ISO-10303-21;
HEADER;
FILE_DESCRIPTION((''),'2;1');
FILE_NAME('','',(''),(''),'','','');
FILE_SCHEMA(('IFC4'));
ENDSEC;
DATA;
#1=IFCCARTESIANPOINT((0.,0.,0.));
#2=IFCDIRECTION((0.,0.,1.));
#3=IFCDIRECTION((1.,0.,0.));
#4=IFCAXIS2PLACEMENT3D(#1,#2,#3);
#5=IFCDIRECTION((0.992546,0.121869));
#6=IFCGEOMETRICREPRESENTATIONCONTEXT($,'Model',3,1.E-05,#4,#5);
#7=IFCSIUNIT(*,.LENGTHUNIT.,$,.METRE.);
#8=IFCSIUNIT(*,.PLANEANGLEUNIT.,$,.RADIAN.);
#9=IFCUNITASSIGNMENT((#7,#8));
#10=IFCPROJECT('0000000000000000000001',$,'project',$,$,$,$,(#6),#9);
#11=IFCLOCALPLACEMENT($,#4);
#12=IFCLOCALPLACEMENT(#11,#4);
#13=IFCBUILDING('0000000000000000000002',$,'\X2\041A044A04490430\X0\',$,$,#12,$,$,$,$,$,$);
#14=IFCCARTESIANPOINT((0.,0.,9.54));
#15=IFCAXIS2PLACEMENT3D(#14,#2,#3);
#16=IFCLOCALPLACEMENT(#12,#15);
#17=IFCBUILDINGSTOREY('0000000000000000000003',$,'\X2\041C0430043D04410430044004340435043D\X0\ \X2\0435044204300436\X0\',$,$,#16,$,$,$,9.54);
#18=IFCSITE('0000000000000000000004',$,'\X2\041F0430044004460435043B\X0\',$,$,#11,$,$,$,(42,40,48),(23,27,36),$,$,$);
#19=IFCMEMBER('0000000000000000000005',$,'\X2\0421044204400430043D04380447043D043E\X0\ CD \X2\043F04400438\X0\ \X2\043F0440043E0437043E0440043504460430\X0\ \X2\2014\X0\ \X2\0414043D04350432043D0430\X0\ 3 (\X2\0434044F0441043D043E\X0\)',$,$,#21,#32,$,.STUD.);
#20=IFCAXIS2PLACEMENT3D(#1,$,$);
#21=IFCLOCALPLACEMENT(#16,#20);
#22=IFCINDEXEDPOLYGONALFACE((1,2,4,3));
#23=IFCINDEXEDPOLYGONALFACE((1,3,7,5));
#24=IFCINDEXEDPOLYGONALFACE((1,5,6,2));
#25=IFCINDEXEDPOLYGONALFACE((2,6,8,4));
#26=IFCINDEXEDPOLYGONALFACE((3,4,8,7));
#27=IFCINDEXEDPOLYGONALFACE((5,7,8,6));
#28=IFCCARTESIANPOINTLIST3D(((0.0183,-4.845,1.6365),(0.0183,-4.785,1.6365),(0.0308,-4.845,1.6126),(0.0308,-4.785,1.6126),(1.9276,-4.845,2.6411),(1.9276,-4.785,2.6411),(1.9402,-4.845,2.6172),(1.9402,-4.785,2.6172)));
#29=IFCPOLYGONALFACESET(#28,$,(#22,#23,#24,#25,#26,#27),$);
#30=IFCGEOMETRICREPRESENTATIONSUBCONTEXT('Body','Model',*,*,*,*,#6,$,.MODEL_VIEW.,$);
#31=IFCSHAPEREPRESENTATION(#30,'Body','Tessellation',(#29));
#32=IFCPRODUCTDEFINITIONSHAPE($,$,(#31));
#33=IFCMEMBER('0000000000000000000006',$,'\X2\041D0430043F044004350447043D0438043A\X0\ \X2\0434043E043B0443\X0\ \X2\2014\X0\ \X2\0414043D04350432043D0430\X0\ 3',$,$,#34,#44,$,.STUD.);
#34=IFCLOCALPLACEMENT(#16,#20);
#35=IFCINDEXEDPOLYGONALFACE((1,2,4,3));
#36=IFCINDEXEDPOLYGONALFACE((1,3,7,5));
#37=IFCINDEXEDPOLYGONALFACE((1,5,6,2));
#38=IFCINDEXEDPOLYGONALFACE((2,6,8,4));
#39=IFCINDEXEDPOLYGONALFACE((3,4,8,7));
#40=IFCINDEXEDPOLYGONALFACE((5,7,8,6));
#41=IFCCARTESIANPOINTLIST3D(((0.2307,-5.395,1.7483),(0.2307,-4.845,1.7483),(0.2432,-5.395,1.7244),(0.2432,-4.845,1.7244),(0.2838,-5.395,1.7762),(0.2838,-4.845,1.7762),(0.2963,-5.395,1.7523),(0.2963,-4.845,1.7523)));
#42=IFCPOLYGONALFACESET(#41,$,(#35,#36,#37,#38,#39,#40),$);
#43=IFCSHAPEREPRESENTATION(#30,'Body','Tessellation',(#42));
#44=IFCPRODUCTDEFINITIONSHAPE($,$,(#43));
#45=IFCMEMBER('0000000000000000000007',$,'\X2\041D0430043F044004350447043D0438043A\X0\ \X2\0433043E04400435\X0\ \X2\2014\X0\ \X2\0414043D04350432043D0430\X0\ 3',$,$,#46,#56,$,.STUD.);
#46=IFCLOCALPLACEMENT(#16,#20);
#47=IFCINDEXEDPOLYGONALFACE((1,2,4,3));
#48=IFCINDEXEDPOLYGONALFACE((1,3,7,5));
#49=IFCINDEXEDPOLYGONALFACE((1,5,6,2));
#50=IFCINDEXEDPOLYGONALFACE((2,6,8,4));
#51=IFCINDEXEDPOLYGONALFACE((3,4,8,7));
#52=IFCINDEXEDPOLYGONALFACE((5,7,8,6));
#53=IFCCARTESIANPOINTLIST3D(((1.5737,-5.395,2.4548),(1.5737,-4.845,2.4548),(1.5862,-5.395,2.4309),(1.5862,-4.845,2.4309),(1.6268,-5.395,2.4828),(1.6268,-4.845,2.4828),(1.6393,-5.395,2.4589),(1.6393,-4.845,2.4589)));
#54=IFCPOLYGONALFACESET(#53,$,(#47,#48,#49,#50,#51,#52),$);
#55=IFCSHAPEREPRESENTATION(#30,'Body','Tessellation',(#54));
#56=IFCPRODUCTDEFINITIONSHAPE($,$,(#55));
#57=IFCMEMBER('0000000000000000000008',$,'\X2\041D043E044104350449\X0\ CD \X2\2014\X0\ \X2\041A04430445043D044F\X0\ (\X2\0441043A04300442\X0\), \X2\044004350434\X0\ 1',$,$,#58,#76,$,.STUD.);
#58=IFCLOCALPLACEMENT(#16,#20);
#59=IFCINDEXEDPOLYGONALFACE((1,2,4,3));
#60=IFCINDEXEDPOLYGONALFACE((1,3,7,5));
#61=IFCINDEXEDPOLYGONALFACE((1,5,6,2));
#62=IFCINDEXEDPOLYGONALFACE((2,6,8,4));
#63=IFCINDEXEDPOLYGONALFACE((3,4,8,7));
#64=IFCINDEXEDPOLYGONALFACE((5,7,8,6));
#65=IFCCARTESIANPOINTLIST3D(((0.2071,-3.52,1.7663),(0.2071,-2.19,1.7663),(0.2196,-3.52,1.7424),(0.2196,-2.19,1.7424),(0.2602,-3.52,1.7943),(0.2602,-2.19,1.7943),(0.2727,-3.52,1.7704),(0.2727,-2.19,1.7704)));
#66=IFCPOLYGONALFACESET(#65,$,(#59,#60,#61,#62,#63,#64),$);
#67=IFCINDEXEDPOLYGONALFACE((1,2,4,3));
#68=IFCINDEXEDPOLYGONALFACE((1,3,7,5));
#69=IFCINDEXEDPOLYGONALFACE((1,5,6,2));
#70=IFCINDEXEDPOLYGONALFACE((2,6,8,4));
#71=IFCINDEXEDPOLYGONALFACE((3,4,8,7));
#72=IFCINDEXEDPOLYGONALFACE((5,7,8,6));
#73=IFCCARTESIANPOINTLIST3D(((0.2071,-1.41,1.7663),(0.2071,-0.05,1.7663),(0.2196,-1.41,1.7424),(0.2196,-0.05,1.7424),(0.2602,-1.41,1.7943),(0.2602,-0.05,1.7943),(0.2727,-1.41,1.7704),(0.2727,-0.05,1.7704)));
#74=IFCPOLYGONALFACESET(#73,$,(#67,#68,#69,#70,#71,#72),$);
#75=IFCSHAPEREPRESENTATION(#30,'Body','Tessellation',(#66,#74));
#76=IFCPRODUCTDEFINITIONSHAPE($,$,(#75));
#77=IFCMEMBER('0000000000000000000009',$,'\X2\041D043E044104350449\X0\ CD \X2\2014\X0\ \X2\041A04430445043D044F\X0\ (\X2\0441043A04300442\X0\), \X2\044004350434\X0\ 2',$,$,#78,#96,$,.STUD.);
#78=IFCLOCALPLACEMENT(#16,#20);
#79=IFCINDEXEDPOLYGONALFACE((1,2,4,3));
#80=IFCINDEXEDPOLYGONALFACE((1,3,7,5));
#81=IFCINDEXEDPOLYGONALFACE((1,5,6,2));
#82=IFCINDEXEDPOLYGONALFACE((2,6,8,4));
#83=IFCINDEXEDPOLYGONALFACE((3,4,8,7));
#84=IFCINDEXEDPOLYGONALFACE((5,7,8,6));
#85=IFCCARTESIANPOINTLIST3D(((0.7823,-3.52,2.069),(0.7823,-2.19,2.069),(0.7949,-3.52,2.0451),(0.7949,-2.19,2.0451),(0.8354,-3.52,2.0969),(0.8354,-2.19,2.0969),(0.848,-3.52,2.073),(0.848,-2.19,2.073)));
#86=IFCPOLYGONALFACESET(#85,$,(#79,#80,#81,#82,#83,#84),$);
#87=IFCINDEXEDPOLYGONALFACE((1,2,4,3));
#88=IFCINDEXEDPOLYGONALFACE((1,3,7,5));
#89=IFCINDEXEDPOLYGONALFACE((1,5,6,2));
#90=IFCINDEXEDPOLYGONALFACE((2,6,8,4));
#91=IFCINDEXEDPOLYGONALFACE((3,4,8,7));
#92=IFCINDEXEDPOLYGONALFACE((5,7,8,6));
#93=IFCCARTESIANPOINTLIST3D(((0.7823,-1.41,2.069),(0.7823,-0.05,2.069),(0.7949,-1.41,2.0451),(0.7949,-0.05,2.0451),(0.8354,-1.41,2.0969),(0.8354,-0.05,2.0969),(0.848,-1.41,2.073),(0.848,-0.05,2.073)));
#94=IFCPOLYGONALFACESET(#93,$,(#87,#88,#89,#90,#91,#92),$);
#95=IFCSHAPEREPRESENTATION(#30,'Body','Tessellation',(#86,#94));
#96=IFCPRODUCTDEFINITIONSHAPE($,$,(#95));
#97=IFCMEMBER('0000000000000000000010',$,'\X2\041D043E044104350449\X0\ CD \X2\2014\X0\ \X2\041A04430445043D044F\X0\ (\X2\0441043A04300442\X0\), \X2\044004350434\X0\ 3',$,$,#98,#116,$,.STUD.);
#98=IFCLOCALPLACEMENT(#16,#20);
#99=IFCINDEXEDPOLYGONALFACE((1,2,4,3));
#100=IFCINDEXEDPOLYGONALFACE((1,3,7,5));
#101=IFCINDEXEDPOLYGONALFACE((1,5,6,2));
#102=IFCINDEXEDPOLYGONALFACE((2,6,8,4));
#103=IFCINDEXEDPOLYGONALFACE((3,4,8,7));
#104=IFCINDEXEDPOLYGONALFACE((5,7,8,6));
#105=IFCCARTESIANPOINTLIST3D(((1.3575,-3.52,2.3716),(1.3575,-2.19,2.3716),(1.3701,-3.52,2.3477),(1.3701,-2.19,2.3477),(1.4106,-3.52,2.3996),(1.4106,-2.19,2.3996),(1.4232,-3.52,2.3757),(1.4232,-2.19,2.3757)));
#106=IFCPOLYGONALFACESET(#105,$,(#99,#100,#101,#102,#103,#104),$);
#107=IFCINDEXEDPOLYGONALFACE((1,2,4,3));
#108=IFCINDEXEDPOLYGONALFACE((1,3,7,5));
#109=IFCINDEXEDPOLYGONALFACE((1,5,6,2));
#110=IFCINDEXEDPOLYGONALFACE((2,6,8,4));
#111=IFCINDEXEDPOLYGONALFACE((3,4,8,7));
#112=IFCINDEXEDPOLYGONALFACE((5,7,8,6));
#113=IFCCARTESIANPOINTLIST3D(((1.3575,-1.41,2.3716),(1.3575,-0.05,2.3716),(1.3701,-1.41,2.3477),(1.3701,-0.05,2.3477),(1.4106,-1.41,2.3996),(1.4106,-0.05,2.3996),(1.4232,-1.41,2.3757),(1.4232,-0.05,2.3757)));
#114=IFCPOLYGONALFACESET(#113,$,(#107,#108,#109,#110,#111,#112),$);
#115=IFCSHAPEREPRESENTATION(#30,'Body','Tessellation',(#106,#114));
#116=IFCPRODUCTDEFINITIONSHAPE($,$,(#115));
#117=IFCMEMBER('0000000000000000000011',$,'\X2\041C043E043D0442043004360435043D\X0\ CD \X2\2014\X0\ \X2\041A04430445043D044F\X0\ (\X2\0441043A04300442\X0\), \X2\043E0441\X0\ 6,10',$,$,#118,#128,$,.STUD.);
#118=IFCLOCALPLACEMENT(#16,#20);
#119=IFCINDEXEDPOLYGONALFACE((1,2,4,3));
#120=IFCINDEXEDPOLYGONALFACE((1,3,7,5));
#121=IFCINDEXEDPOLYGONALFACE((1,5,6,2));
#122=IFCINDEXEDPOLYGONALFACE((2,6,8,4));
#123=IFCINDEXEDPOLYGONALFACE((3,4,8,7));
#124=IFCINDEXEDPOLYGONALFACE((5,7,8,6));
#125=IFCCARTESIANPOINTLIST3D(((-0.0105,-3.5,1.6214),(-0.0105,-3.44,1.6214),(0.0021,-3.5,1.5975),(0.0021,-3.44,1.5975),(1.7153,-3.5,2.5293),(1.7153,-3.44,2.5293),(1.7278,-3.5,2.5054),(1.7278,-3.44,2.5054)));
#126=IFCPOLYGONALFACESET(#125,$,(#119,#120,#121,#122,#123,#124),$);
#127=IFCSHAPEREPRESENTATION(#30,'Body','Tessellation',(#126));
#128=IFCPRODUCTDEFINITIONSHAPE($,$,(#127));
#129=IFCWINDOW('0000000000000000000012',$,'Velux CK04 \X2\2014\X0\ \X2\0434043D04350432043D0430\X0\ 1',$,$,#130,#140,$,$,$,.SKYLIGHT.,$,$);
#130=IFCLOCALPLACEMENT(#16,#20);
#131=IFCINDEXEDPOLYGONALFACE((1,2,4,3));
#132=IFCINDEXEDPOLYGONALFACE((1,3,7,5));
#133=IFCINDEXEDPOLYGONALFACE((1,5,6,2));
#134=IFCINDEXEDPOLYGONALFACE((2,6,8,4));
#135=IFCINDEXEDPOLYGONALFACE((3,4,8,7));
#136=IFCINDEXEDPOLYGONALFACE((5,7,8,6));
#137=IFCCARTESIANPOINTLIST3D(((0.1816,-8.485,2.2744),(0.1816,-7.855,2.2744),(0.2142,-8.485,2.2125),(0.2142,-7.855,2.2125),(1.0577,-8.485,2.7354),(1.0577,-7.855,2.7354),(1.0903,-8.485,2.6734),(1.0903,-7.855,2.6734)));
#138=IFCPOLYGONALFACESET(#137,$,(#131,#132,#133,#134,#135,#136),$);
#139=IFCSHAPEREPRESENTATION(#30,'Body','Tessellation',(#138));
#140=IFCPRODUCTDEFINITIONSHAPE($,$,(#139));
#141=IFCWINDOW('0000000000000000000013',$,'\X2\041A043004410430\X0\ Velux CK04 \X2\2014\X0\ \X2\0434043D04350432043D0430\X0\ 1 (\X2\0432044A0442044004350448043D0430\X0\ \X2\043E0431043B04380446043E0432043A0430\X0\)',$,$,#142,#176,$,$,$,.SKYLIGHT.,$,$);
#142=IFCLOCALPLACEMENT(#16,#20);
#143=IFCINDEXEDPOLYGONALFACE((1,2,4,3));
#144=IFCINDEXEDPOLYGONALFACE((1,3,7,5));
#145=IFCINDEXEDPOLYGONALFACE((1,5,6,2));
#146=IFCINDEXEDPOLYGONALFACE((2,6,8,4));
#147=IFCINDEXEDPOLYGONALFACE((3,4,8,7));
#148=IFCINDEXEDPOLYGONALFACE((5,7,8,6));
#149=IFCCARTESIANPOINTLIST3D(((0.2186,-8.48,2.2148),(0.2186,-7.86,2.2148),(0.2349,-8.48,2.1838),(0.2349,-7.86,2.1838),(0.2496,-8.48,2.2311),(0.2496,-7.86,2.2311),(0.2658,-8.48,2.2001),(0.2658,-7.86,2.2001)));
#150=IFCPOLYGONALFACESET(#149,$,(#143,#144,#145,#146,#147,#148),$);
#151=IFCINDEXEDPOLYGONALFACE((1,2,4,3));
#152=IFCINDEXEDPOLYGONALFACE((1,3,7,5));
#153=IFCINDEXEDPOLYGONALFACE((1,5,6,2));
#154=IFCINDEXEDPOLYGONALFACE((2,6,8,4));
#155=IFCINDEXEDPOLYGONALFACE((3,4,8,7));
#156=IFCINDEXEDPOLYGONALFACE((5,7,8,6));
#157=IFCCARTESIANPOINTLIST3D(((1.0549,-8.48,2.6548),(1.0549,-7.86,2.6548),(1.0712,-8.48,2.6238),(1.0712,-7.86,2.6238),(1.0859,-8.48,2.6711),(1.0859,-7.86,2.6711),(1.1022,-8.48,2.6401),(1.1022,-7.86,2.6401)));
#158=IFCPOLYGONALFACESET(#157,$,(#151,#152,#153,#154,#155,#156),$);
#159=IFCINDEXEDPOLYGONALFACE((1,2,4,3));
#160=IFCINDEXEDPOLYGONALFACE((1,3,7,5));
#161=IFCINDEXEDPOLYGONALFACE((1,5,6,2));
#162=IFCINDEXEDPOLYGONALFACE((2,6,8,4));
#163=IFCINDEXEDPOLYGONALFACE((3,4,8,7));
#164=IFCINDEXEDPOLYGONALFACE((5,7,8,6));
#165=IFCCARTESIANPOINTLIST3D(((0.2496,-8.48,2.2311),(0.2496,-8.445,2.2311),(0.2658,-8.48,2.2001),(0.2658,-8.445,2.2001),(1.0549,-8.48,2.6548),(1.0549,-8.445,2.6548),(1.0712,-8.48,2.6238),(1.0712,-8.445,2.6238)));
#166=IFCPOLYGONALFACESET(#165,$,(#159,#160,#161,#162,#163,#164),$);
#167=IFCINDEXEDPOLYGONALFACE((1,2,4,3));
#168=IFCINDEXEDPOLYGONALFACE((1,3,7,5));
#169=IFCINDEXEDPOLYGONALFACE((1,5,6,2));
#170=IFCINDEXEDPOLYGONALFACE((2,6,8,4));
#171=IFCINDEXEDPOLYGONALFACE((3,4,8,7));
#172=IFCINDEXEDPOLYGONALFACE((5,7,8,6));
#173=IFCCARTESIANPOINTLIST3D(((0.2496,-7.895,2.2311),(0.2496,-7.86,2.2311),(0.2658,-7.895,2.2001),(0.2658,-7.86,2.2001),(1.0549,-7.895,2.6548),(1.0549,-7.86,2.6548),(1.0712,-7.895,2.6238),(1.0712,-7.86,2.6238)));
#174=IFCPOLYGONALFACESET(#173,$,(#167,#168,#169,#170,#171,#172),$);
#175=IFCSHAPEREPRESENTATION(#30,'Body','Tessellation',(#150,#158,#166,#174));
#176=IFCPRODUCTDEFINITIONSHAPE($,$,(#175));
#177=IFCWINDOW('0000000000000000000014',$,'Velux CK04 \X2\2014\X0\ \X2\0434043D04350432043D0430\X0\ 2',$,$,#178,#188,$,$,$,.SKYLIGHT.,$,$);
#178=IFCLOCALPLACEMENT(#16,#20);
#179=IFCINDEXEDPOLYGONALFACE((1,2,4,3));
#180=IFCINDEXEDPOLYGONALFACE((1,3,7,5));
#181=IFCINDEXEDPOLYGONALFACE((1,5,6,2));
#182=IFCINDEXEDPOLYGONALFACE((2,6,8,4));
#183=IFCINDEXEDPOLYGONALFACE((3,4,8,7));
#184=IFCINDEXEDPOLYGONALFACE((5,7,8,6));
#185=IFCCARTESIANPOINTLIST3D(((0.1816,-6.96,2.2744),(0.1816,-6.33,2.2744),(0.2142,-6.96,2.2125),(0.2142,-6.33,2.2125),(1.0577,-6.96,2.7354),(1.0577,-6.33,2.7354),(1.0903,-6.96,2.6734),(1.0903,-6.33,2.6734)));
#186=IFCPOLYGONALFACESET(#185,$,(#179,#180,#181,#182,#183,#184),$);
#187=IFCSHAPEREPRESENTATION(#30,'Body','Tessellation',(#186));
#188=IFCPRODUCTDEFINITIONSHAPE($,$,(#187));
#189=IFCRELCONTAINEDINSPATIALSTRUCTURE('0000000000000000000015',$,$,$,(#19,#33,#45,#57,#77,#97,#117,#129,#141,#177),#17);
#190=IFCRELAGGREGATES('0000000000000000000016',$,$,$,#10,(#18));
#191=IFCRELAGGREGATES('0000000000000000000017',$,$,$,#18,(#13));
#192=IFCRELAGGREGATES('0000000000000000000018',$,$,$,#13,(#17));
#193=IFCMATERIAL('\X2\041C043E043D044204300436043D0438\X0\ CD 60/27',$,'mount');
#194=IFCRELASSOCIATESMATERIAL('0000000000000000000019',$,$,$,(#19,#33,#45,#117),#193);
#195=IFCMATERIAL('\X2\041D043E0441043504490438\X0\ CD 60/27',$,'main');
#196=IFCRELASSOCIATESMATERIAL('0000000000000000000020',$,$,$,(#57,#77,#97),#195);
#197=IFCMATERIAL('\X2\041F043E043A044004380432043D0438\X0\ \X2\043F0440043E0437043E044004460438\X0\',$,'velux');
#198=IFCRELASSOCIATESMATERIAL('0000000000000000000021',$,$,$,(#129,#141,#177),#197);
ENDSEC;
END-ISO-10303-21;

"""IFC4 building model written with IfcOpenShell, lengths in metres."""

from ifc_helpers import new_model, si_unit, direction, frame, origin_with_axes, place, context, subcontext, project, spatial, polyline, outline, extrude, material, element, save


model = new_model("IFC4")

# Units and contexts
model_context = context("Model", 3, precision=1e-05, world=origin_with_axes(), true_north=direction((0.992546, 0.121869)))
body_context = subcontext(model_context, "Body", "Model", "MODEL_VIEW")
ifc_project = project(units=[si_unit("LENGTHUNIT", "METRE"), si_unit("PLANEANGLEUNIT", "RADIAN")], contexts=[model_context])

# Site, building, storey
site_placement = place(None, origin_with_axes())
site = spatial("IfcSite", under=ifc_project, at=site_placement, Name="Парцел", RefLatitude=(42, 40, 48), RefLongitude=(23, 27, 36))
building_placement = place(site_placement, origin_with_axes())
building = spatial("IfcBuilding", under=site, at=building_placement, Name="Къща")
storey_placement = place(building_placement, frame((0.0, 0.0, 9.54), z_axis=(0.0, 0.0, 1.0), x_axis=(1.0, 0.0, 0.0)))
storey = spatial("IfcBuildingStorey", under=building, at=storey_placement, Name="Мансарден етаж", Elevation=9.54)

# Members
ifc_material_1 = material(Name="Монтажни CD 60/27", Category="mount")
member_1_placement = place(storey_placement, origin_with_axes())
element("IfcMember", 1, at=member_1_placement, inside=storey, material=ifc_material_1, Name="Странично CD при прозореца — Дневна 3 (дясно)", PredefinedType="STUD", context=body_context, shape_type="SweptSolid", body=[
    extrude(outline(polyline([(0.0308, -1.6126), (1.9402, -2.6172), (1.9277, -2.6411), (0.0183, -1.6365), (0.0308, -1.6126)])), frame((0.0, -4.845, 0.0), z_axis=(0.0, 1.0, 0.0), x_axis=(1.0, 0.0, 0.0)), (0.0, 0.0, 1.0), 0.06),
])
member_2_placement = place(storey_placement, origin_with_axes())
element("IfcMember", 2, at=member_2_placement, inside=storey, material=ifc_material_1, Name="Напречник долу — Дневна 3", PredefinedType="STUD", context=body_context, shape_type="SweptSolid", body=[
    extrude(outline(polyline([(0.2432, -1.7244), (0.2963, -1.7523), (0.2838, -1.7762), (0.2307, -1.7483), (0.2432, -1.7244)])), frame((0.0, -5.395, 0.0), z_axis=(0.0, 1.0, 0.0), x_axis=(1.0, 0.0, 0.0)), (0.0, 0.0, 1.0), 0.55),
])
member_3_placement = place(storey_placement, origin_with_axes())
element("IfcMember", 3, at=member_3_placement, inside=storey, material=ifc_material_1, Name="Напречник горе — Дневна 3", PredefinedType="STUD", context=body_context, shape_type="SweptSolid", body=[
    extrude(outline(polyline([(1.5862, -2.4309), (1.6393, -2.4589), (1.6268, -2.4828), (1.5737, -2.4548), (1.5862, -2.4309)])), frame((0.0, -5.395, 0.0), z_axis=(0.0, 1.0, 0.0), x_axis=(1.0, 0.0, 0.0)), (0.0, 0.0, 1.0), 0.55),
])
ifc_material_2 = material(Name="Носещи CD 60/27", Category="main")
member_4_placement = place(storey_placement, origin_with_axes())
element("IfcMember", 4, at=member_4_placement, inside=storey, material=ifc_material_2, Name="Носещ CD — Кухня (скат), ред 1", PredefinedType="STUD", context=body_context, shape_type="SweptSolid", body=[
    extrude(outline(polyline([(0.2196, -1.7424), (0.2727, -1.7704), (0.2602, -1.7943), (0.2071, -1.7663), (0.2196, -1.7424)])), frame((0.0, -3.52, 0.0), z_axis=(0.0, 1.0, 0.0), x_axis=(1.0, 0.0, 0.0)), (0.0, 0.0, 1.0), 1.33),
    extrude(outline(polyline([(0.2196, -1.7424), (0.2727, -1.7704), (0.2602, -1.7943), (0.2071, -1.7663), (0.2196, -1.7424)])), frame((0.0, -1.41, 0.0), z_axis=(0.0, 1.0, 0.0), x_axis=(1.0, 0.0, 0.0)), (0.0, 0.0, 1.0), 1.36),
])
member_5_placement = place(storey_placement, origin_with_axes())
element("IfcMember", 5, at=member_5_placement, inside=storey, material=ifc_material_2, Name="Носещ CD — Кухня (скат), ред 2", PredefinedType="STUD", context=body_context, shape_type="SweptSolid", body=[
    extrude(outline(polyline([(0.7949, -2.0451), (0.848, -2.073), (0.8354, -2.0969), (0.7823, -2.069), (0.7949, -2.0451)])), frame((0.0, -3.52, 0.0), z_axis=(0.0, 1.0, 0.0), x_axis=(1.0, 0.0, 0.0)), (0.0, 0.0, 1.0), 1.33),
    extrude(outline(polyline([(0.7949, -2.0451), (0.848, -2.073), (0.8354, -2.0969), (0.7823, -2.069), (0.7949, -2.0451)])), frame((0.0, -1.41, 0.0), z_axis=(0.0, 1.0, 0.0), x_axis=(1.0, 0.0, 0.0)), (0.0, 0.0, 1.0), 1.36),
])
member_6_placement = place(storey_placement, origin_with_axes())
element("IfcMember", 6, at=member_6_placement, inside=storey, material=ifc_material_2, Name="Носещ CD — Кухня (скат), ред 3", PredefinedType="STUD", context=body_context, shape_type="SweptSolid", body=[
    extrude(outline(polyline([(1.3701, -2.3477), (1.4232, -2.3757), (1.4106, -2.3996), (1.3575, -2.3716), (1.3701, -2.3477)])), frame((0.0, -3.52, 0.0), z_axis=(0.0, 1.0, 0.0), x_axis=(1.0, 0.0, 0.0)), (0.0, 0.0, 1.0), 1.33),
    extrude(outline(polyline([(1.3701, -2.3477), (1.4232, -2.3757), (1.4106, -2.3996), (1.3575, -2.3716), (1.3701, -2.3477)])), frame((0.0, -1.41, 0.0), z_axis=(0.0, 1.0, 0.0), x_axis=(1.0, 0.0, 0.0)), (0.0, 0.0, 1.0), 1.36),
])
member_7_placement = place(storey_placement, origin_with_axes())
element("IfcMember", 7, at=member_7_placement, inside=storey, material=ifc_material_1, Name="Монтажен CD — Кухня (скат), ос 6,10", PredefinedType="STUD", context=body_context, shape_type="SweptSolid", body=[
    extrude(outline(polyline([(0.0021, -1.5975), (1.7278, -2.5054), (1.7153, -2.5293), (-0.0105, -1.6214), (0.0021, -1.5975)])), frame((0.0, -3.5, 0.0), z_axis=(0.0, 1.0, 0.0), x_axis=(1.0, 0.0, 0.0)), (0.0, 0.0, 1.0), 0.06),
])

# Windows
ifc_material_3 = material(Name="Покривни прозорци", Category="velux")
window_1_placement = place(storey_placement, origin_with_axes())
element("IfcWindow", 8, at=window_1_placement, inside=storey, material=ifc_material_3, Name="Velux CK04 — дневна 1", PredefinedType="SKYLIGHT", context=body_context, shape_type="SweptSolid", body=[
    extrude(outline(polyline([(0.2142, -2.2125), (1.0903, -2.6734), (1.0577, -2.7354), (0.1816, -2.2744), (0.2142, -2.2125)])), frame((0.0, -8.485, 0.0), z_axis=(0.0, 1.0, 0.0), x_axis=(1.0, 0.0, 0.0)), (0.0, 0.0, 1.0), 0.63),
])
window_2_placement = place(storey_placement, origin_with_axes())
element("IfcWindow", 9, at=window_2_placement, inside=storey, material=ifc_material_3, Name="Каса Velux CK04 — дневна 1 (вътрешна облицовка)", PredefinedType="SKYLIGHT", context=body_context, shape_type="SweptSolid", body=[
    extrude(outline(polyline([(0.2349, -2.1838), (0.2658, -2.2001), (0.2496, -2.2311), (0.2186, -2.2148), (0.2349, -2.1838)])), frame((0.0, -8.48, 0.0), z_axis=(0.0, 1.0, 0.0), x_axis=(1.0, 0.0, 0.0)), (0.0, 0.0, 1.0), 0.62),
    extrude(outline(polyline([(1.0712, -2.6238), (1.1022, -2.6401), (1.0859, -2.6711), (1.0549, -2.6548), (1.0712, -2.6238)])), frame((0.0, -8.48, 0.0), z_axis=(0.0, 1.0, 0.0), x_axis=(1.0, 0.0, 0.0)), (0.0, 0.0, 1.0), 0.62),
    extrude(outline(polyline([(0.2658, -2.2001), (1.0712, -2.6238), (1.0549, -2.6548), (0.2496, -2.2311), (0.2658, -2.2001)])), frame((0.0, -8.48, 0.0), z_axis=(0.0, 1.0, 0.0), x_axis=(1.0, 0.0, 0.0)), (0.0, 0.0, 1.0), 0.035),
    extrude(outline(polyline([(0.2658, -2.2001), (1.0712, -2.6238), (1.0549, -2.6548), (0.2496, -2.2311), (0.2658, -2.2001)])), frame((0.0, -7.895, 0.0), z_axis=(0.0, 1.0, 0.0), x_axis=(1.0, 0.0, 0.0)), (0.0, 0.0, 1.0), 0.035),
])
window_3_placement = place(storey_placement, origin_with_axes())
element("IfcWindow", 10, at=window_3_placement, inside=storey, material=ifc_material_3, Name="Velux CK04 — дневна 2", PredefinedType="SKYLIGHT", context=body_context, shape_type="SweptSolid", body=[
    extrude(outline(polyline([(0.2142, -2.2125), (1.0903, -2.6734), (1.0577, -2.7354), (0.1816, -2.2744), (0.2142, -2.2125)])), frame((0.0, -6.96, 0.0), z_axis=(0.0, 1.0, 0.0), x_axis=(1.0, 0.0, 0.0)), (0.0, 0.0, 1.0), 0.63),
])

save(model, "model.ifc")
